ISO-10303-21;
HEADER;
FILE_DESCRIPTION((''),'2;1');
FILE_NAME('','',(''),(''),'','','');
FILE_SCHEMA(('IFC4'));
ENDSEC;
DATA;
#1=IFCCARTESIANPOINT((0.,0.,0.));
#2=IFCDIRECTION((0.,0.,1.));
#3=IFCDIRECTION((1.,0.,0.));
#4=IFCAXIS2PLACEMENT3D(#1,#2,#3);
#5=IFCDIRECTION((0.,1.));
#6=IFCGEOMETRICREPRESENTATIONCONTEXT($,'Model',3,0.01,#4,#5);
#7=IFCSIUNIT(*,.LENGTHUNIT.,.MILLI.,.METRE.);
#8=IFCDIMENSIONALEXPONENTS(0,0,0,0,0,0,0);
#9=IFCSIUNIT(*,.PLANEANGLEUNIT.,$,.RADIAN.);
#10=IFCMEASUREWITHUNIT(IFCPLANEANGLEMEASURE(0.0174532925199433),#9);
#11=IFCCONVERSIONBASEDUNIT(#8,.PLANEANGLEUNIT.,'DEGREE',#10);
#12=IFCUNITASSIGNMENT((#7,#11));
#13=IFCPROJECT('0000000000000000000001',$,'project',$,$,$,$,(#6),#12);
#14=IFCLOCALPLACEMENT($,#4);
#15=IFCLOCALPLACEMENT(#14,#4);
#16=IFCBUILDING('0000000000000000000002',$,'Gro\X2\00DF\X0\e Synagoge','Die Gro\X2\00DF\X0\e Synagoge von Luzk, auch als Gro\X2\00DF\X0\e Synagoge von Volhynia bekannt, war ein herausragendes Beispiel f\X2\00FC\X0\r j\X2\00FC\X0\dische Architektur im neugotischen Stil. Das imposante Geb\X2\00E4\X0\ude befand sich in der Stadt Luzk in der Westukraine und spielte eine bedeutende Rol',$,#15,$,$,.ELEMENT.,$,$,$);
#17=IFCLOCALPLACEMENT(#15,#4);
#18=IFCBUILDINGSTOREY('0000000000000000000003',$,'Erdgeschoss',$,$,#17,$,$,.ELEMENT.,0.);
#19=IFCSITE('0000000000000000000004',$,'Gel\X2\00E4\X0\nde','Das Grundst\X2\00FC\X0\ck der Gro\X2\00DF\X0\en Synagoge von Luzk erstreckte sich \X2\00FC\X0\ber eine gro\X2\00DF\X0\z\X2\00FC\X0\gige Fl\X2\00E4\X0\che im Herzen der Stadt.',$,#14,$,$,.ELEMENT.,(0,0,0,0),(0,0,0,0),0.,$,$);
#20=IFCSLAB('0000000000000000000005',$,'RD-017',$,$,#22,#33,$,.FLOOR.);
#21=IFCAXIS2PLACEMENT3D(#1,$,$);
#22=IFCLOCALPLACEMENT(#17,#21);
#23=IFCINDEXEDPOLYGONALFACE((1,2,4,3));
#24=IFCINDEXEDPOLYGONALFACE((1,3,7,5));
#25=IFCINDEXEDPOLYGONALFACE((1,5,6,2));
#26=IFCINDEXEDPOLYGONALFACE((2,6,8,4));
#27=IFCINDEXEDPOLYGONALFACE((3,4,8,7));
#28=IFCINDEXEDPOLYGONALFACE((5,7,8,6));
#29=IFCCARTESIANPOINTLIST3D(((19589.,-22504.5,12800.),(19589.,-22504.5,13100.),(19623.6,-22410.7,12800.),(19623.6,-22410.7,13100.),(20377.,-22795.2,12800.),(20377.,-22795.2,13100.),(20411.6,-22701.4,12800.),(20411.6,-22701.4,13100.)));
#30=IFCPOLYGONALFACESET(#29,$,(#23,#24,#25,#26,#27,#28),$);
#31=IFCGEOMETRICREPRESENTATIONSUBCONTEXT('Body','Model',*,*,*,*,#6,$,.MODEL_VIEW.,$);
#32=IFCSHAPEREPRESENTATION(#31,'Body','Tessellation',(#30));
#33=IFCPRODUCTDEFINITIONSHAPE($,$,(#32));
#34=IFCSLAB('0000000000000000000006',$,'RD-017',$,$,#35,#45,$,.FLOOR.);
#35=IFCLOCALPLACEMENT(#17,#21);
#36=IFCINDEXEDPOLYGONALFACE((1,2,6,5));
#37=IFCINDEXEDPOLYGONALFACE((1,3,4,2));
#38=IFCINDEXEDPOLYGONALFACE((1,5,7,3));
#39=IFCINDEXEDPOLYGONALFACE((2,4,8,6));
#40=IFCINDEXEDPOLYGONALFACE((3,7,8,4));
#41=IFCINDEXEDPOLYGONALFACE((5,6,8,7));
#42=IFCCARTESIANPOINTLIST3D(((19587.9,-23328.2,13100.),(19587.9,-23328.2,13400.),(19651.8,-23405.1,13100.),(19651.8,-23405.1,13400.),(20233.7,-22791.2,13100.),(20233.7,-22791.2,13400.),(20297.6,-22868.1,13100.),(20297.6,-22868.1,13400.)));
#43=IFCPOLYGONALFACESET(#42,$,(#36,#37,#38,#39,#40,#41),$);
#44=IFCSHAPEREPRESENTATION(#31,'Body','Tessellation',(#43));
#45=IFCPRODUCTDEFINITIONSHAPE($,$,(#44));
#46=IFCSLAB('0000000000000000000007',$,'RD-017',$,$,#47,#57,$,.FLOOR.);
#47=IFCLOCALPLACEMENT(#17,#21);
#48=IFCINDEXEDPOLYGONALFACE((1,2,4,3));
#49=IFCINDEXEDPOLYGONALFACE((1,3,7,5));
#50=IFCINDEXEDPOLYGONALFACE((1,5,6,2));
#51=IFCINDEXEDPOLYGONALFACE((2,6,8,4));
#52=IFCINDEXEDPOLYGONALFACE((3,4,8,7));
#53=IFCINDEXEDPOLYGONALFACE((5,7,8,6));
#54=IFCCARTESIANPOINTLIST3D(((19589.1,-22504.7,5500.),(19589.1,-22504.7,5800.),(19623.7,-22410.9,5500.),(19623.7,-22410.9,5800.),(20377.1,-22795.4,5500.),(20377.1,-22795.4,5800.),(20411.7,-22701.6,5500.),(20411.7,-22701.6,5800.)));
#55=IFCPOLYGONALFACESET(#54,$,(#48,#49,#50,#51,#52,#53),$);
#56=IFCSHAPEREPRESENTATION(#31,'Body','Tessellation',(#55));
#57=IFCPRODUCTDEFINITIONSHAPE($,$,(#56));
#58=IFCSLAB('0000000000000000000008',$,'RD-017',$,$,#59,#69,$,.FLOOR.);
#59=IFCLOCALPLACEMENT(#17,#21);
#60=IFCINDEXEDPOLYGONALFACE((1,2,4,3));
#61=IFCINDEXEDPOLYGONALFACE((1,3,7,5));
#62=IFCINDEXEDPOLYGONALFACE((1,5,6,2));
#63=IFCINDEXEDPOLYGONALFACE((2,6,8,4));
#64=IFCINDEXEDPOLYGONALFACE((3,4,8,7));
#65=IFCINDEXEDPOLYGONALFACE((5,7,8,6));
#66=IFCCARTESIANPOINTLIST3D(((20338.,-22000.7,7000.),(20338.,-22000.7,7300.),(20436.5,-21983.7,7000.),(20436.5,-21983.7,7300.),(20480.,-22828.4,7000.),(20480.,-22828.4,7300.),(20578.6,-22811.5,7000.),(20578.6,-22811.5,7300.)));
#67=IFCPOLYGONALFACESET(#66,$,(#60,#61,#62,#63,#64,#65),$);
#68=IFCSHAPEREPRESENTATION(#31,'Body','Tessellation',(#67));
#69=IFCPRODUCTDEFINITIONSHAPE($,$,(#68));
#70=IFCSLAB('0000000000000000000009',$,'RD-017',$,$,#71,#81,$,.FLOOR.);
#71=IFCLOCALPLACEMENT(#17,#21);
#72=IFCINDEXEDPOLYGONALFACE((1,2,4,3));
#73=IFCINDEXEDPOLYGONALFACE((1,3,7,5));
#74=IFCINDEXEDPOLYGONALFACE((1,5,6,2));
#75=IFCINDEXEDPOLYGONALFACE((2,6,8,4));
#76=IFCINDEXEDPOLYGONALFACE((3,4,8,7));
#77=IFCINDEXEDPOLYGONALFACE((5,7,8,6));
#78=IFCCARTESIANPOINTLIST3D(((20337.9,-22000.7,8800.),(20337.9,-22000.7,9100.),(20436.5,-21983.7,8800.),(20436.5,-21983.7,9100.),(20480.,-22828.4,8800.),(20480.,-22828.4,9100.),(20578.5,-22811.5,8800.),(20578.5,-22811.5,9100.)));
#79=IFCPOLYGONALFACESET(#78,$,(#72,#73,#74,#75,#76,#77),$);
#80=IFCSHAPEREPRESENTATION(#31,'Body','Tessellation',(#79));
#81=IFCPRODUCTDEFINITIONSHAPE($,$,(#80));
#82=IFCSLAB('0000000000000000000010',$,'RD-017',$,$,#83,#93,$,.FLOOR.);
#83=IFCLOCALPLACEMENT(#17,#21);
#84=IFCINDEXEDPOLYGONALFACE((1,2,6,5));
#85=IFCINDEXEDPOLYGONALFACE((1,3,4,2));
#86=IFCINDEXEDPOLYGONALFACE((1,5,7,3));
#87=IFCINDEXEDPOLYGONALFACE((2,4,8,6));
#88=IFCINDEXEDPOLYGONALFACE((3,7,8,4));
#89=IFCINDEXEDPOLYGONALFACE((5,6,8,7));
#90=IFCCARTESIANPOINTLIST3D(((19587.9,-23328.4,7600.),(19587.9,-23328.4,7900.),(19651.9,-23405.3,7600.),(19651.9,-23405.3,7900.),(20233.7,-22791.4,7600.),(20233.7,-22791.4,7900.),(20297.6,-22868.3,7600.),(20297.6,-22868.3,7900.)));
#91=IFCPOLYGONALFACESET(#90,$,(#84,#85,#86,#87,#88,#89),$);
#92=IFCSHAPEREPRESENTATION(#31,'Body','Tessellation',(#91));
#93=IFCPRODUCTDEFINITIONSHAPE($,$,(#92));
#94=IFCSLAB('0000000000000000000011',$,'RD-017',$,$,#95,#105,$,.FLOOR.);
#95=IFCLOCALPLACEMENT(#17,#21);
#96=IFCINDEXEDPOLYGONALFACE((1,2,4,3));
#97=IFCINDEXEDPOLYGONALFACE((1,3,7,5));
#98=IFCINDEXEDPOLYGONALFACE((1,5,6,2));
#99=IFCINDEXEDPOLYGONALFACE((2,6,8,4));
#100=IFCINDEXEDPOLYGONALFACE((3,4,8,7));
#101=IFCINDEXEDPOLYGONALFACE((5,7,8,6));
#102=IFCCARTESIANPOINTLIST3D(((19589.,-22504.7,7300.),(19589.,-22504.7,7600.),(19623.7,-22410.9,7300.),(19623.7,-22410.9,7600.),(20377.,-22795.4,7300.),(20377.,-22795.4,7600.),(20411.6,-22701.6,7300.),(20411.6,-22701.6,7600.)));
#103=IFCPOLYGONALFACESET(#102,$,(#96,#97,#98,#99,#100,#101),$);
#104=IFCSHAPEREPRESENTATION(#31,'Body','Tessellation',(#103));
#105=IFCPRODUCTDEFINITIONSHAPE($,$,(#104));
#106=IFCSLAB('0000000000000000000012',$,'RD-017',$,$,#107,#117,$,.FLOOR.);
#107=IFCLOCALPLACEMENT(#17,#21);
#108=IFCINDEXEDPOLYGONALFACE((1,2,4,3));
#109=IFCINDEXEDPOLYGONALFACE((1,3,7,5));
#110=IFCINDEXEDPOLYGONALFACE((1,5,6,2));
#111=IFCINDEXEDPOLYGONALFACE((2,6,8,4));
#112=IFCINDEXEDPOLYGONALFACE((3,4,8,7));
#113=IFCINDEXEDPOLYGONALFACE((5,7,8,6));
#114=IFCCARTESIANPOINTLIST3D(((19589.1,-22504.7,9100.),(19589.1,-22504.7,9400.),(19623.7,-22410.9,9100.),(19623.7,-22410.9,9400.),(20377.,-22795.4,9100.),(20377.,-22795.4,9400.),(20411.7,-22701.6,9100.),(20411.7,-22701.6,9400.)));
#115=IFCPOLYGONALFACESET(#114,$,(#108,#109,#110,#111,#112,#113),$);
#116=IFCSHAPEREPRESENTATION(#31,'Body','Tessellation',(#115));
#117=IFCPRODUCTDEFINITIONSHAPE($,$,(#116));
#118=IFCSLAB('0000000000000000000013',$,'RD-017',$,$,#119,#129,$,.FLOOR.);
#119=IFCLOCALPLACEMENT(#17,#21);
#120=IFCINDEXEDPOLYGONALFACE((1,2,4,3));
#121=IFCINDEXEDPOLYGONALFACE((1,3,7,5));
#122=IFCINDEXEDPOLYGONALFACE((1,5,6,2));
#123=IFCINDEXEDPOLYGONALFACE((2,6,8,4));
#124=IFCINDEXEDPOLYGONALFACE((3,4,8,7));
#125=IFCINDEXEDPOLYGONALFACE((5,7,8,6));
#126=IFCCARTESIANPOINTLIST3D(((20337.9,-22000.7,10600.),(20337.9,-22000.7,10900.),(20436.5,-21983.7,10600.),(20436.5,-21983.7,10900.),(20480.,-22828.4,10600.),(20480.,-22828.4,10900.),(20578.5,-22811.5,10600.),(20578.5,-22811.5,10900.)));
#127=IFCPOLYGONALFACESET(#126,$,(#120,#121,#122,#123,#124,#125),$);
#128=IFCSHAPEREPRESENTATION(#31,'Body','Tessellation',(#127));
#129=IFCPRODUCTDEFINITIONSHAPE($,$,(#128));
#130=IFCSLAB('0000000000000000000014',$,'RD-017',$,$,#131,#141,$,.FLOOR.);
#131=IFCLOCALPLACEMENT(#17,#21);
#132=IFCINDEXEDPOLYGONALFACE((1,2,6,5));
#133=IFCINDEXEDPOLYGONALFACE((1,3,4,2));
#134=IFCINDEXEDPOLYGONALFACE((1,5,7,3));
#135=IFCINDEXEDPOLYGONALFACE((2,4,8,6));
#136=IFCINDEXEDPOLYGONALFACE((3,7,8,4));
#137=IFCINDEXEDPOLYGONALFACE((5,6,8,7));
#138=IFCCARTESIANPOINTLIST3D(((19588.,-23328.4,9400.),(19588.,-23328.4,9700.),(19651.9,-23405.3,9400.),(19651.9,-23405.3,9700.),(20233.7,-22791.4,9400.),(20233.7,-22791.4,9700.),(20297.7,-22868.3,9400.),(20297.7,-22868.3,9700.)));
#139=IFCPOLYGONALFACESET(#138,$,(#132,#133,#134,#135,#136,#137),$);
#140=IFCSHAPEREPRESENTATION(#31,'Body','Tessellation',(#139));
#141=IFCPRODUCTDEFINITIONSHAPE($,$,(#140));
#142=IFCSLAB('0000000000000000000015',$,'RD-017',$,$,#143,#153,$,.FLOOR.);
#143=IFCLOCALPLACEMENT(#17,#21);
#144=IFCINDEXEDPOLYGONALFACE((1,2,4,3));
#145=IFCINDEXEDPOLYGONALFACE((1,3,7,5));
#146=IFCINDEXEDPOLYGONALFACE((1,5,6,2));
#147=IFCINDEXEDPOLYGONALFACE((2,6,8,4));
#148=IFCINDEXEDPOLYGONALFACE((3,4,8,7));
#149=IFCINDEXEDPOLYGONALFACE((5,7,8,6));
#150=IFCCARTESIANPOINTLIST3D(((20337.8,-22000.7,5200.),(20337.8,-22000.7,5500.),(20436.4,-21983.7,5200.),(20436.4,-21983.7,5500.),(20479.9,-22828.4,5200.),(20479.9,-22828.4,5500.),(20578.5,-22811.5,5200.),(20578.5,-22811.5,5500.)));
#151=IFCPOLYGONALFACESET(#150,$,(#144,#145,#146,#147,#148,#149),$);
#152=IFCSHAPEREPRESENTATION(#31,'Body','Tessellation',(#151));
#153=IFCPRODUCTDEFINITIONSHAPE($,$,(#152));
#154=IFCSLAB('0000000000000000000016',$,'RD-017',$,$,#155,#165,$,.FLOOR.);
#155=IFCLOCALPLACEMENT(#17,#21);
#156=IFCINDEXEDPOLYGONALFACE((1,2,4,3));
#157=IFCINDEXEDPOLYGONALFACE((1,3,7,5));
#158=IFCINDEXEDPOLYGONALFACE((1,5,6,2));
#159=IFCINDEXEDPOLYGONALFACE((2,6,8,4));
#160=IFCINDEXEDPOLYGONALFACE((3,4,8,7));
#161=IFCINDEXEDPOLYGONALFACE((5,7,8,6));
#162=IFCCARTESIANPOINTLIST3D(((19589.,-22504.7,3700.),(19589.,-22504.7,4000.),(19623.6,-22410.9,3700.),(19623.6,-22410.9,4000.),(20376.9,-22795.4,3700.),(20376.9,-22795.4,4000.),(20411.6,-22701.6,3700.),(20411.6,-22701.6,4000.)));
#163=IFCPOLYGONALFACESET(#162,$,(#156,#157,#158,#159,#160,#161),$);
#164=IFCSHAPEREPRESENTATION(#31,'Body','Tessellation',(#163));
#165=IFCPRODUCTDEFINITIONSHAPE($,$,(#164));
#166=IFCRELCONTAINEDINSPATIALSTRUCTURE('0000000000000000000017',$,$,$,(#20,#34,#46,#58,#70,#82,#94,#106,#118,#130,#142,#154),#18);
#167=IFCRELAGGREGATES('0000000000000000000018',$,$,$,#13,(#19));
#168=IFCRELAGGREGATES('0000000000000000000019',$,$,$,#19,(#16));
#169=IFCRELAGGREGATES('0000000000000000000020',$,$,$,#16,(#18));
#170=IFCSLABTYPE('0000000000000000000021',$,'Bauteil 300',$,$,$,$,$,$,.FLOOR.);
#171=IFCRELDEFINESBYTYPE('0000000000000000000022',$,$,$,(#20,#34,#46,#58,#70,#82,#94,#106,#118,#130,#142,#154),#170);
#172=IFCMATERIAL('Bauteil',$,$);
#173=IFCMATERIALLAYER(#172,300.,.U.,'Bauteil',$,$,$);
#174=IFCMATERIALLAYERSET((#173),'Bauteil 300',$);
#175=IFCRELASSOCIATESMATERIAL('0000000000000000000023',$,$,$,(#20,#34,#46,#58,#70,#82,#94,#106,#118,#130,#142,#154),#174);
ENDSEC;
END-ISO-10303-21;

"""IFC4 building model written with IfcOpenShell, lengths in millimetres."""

from ifc_helpers import new_model, entity, si_unit, converted_unit, direction, frame, origin_with_axes, place, context, subcontext, project, spatial, line, indexed_curve, outline, extrude, material, layer, layer_set, layer_usage, type_object, element, save


model = new_model("IFC4")

# Units and contexts
model_context = context("Model", 3, precision=0.01, world=origin_with_axes(), true_north=direction((0.0, 1.0)))
body_context = subcontext(model_context, "Body", "Model", "MODEL_VIEW")
ifc_project = project(units=[si_unit("LENGTHUNIT", "METRE", prefix="MILLI"), converted_unit("PLANEANGLEUNIT", "DEGREE", entity("IfcPlaneAngleMeasure", 0.0174532925199433), si_unit("PLANEANGLEUNIT", "RADIAN"), dimensions=[0, 0, 0, 0, 0, 0, 0])], contexts=[model_context])

# Site, building, storey
site_placement = place(None, origin_with_axes())
site = spatial("IfcSite", under=ifc_project, at=site_placement, Name="Gelände", Description="Das Grundstück der Großen Synagoge von Luzk erstreckte sich über eine großzügige Fläche im Herzen der Stadt.", CompositionType="ELEMENT", RefLatitude=(0, 0, 0, 0), RefLongitude=(0, 0, 0, 0), RefElevation=0.0)
building_placement = place(site_placement, origin_with_axes())
building = spatial("IfcBuilding", under=site, at=building_placement, Name="Große Synagoge", Description="Die Große Synagoge von Luzk, auch als Große Synagoge von Volhynia bekannt, war ein herausragendes Beispiel für jüdische Architektur im neugotischen Stil. Das imposante Gebäude befand sich in der Stadt Luzk in der Westukraine und spielte eine bedeutende Rol", CompositionType="ELEMENT")
storey_placement = place(building_placement, origin_with_axes())
storey = spatial("IfcBuildingStorey", under=building, at=storey_placement, Name="Erdgeschoss", CompositionType="ELEMENT", Elevation=0.0)

# Slabs
ifc_material = material(Name="Bauteil")
ifc_layer_1 = layer(ifc_material, 300.0, ventilated="UNKNOWN", Name="Bauteil")
ifc_layer_set_1 = layer_set([ifc_layer_1], Name="Bauteil 300")
ifc_layer_usage_1 = layer_usage(ifc_layer_set_1, "AXIS3", "NEGATIVE", 300.0)
slab_type_1 = type_object("IfcSlabType", Name="Bauteil 300", PredefinedType="FLOOR")
slab_1_placement = place(storey_placement, frame((20377.0, -22795.2, 13100.0), z_axis=(0.0, 0.0, 1.0), x_axis=(1.0, 0.0, 0.0)))
element("IfcSlab", 1, at=slab_1_placement, inside=storey, type_object=slab_type_1, material=ifc_layer_usage_1, Name="RD-017", PredefinedType="FLOOR", context=body_context, shape_type="SweptSolid", body=[
    extrude(outline(indexed_curve([(0.0, 0.0), (34.6, 93.8), (-753.4, 384.5), (-788.0, 290.7)], segments=[line(1, 2, 3, 4, 1)])), frame((0.0, 0.0, -300.0), z_axis=(0.0, 0.0, 1.0), x_axis=(1.0, 0.0, 0.0)), (0.0, 0.0, 1.0), 300.0),
])
ifc_layer_usage_2 = layer_usage(ifc_layer_set_1, "AXIS3", "NEGATIVE", 300.0)
slab_2_placement = place(storey_placement, frame((20297.6, -22868.1, 13400.0), z_axis=(0.0, 0.0, 1.0), x_axis=(1.0, 0.0, 0.0)))
element("IfcSlab", 2, at=slab_2_placement, inside=storey, type_object=slab_type_1, material=ifc_layer_usage_2, Name="RD-017", PredefinedType="FLOOR", context=body_context, shape_type="SweptSolid", body=[
    extrude(outline(indexed_curve([(0.0, 0.0), (-63.9, 76.9), (-709.7, -460.1), (-645.8, -537.0)], segments=[line(1, 2, 3, 4, 1)])), frame((0.0, 0.0, -300.0), z_axis=(0.0, 0.0, 1.0), x_axis=(1.0, 0.0, 0.0)), (0.0, 0.0, 1.0), 300.0),
])
ifc_layer_usage_3 = layer_usage(ifc_layer_set_1, "AXIS3", "NEGATIVE", 300.0)
slab_3_placement = place(storey_placement, frame((20377.1, -22795.4, 5800.0), z_axis=(0.0, 0.0, 1.0), x_axis=(1.0, 0.0, 0.0)))
element("IfcSlab", 3, at=slab_3_placement, inside=storey, type_object=slab_type_1, material=ifc_layer_usage_3, Name="RD-017", PredefinedType="FLOOR", context=body_context, shape_type="SweptSolid", body=[
    extrude(outline(indexed_curve([(0.0, 0.0), (34.6, 93.8), (-753.4, 384.5), (-788.0, 290.7)], segments=[line(1, 2, 3, 4, 1)])), frame((0.0, 0.0, -300.0), z_axis=(0.0, 0.0, 1.0), x_axis=(1.0, 0.0, 0.0)), (0.0, 0.0, 1.0), 300.0),
])
ifc_layer_usage_4 = layer_usage(ifc_layer_set_1, "AXIS3", "NEGATIVE", 300.0)
slab_4_placement = place(storey_placement, frame((20480.0, -22828.4, 7300.0), z_axis=(0.0, 0.0, 1.0), x_axis=(1.0, 0.0, 0.0)))
element("IfcSlab", 4, at=slab_4_placement, inside=storey, type_object=slab_type_1, material=ifc_layer_usage_4, Name="RD-017", PredefinedType="FLOOR", context=body_context, shape_type="SweptSolid", body=[
    extrude(outline(indexed_curve([(0.0, 0.0), (98.6, 16.9), (-43.5, 844.7), (-142.1, 827.8)], segments=[line(1, 2, 3, 4, 1)])), frame((0.0, 0.0, -300.0), z_axis=(0.0, 0.0, 1.0), x_axis=(1.0, 0.0, 0.0)), (0.0, 0.0, 1.0), 300.0),
])
ifc_layer_usage_5 = layer_usage(ifc_layer_set_1, "AXIS3", "NEGATIVE", 300.0)
slab_5_placement = place(storey_placement, frame((20480.0, -22828.4, 9100.0), z_axis=(0.0, 0.0, 1.0), x_axis=(1.0, 0.0, 0.0)))
element("IfcSlab", 5, at=slab_5_placement, inside=storey, type_object=slab_type_1, material=ifc_layer_usage_5, Name="RD-017", PredefinedType="FLOOR", context=body_context, shape_type="SweptSolid", body=[
    extrude(outline(indexed_curve([(0.0, 0.0), (98.6, 16.9), (-43.5, 844.7), (-142.1, 827.8)], segments=[line(1, 2, 3, 4, 1)])), frame((0.0, 0.0, -300.0), z_axis=(0.0, 0.0, 1.0), x_axis=(1.0, 0.0, 0.0)), (0.0, 0.0, 1.0), 300.0),
])
ifc_layer_usage_6 = layer_usage(ifc_layer_set_1, "AXIS3", "NEGATIVE", 300.0)
slab_6_placement = place(storey_placement, frame((20297.6, -22868.3, 7900.0), z_axis=(0.0, 0.0, 1.0), x_axis=(1.0, 0.0, 0.0)))
element("IfcSlab", 6, at=slab_6_placement, inside=storey, type_object=slab_type_1, material=ifc_layer_usage_6, Name="RD-017", PredefinedType="FLOOR", context=body_context, shape_type="SweptSolid", body=[
    extrude(outline(indexed_curve([(0.0, 0.0), (-63.9, 76.9), (-709.7, -460.1), (-645.8, -537.0)], segments=[line(1, 2, 3, 4, 1)])), frame((0.0, 0.0, -300.0), z_axis=(0.0, 0.0, 1.0), x_axis=(1.0, 0.0, 0.0)), (0.0, 0.0, 1.0), 300.0),
])
ifc_layer_usage_7 = layer_usage(ifc_layer_set_1, "AXIS3", "NEGATIVE", 300.0)
slab_7_placement = place(storey_placement, frame((20377.0, -22795.4, 7600.0), z_axis=(0.0, 0.0, 1.0), x_axis=(1.0, 0.0, 0.0)))
element("IfcSlab", 7, at=slab_7_placement, inside=storey, type_object=slab_type_1, material=ifc_layer_usage_7, Name="RD-017", PredefinedType="FLOOR", context=body_context, shape_type="SweptSolid", body=[
    extrude(outline(indexed_curve([(0.0, 0.0), (34.6, 93.8), (-753.4, 384.5), (-788.0, 290.7)], segments=[line(1, 2, 3, 4, 1)])), frame((0.0, 0.0, -300.0), z_axis=(0.0, 0.0, 1.0), x_axis=(1.0, 0.0, 0.0)), (0.0, 0.0, 1.0), 300.0),
])
ifc_layer_usage_8 = layer_usage(ifc_layer_set_1, "AXIS3", "NEGATIVE", 300.0)
slab_8_placement = place(storey_placement, frame((20377.0, -22795.4, 9400.0), z_axis=(0.0, 0.0, 1.0), x_axis=(1.0, 0.0, 0.0)))
element("IfcSlab", 8, at=slab_8_placement, inside=storey, type_object=slab_type_1, material=ifc_layer_usage_8, Name="RD-017", PredefinedType="FLOOR", context=body_context, shape_type="SweptSolid", body=[
    extrude(outline(indexed_curve([(0.0, 0.0), (34.6, 93.8), (-753.4, 384.5), (-788.0, 290.7)], segments=[line(1, 2, 3, 4, 1)])), frame((0.0, 0.0, -300.0), z_axis=(0.0, 0.0, 1.0), x_axis=(1.0, 0.0, 0.0)), (0.0, 0.0, 1.0), 300.0),
])
ifc_layer_usage_9 = layer_usage(ifc_layer_set_1, "AXIS3", "NEGATIVE", 300.0)
slab_9_placement = place(storey_placement, frame((20480.0, -22828.4, 10900.0), z_axis=(0.0, 0.0, 1.0), x_axis=(1.0, 0.0, 0.0)))
element("IfcSlab", 9, at=slab_9_placement, inside=storey, type_object=slab_type_1, material=ifc_layer_usage_9, Name="RD-017", PredefinedType="FLOOR", context=body_context, shape_type="SweptSolid", body=[
    extrude(outline(indexed_curve([(0.0, 0.0), (98.6, 16.9), (-43.5, 844.7), (-142.1, 827.8)], segments=[line(1, 2, 3, 4, 1)])), frame((0.0, 0.0, -300.0), z_axis=(0.0, 0.0, 1.0), x_axis=(1.0, 0.0, 0.0)), (0.0, 0.0, 1.0), 300.0),
])
ifc_layer_usage_10 = layer_usage(ifc_layer_set_1, "AXIS3", "NEGATIVE", 300.0)
slab_10_placement = place(storey_placement, frame((20297.7, -22868.3, 9700.0), z_axis=(0.0, 0.0, 1.0), x_axis=(1.0, 0.0, 0.0)))
element("IfcSlab", 10, at=slab_10_placement, inside=storey, type_object=slab_type_1, material=ifc_layer_usage_10, Name="RD-017", PredefinedType="FLOOR", context=body_context, shape_type="SweptSolid", body=[
    extrude(outline(indexed_curve([(0.0, 0.0), (-63.9, 76.9), (-709.7, -460.1), (-645.8, -537.0)], segments=[line(1, 2, 3, 4, 1)])), frame((0.0, 0.0, -300.0), z_axis=(0.0, 0.0, 1.0), x_axis=(1.0, 0.0, 0.0)), (0.0, 0.0, 1.0), 300.0),
])
ifc_layer_usage_11 = layer_usage(ifc_layer_set_1, "AXIS3", "NEGATIVE", 300.0)
slab_11_placement = place(storey_placement, frame((20479.9, -22828.4, 5500.0), z_axis=(0.0, 0.0, 1.0), x_axis=(1.0, 0.0, 0.0)))
element("IfcSlab", 11, at=slab_11_placement, inside=storey, type_object=slab_type_1, material=ifc_layer_usage_11, Name="RD-017", PredefinedType="FLOOR", context=body_context, shape_type="SweptSolid", body=[
    extrude(outline(indexed_curve([(0.0, 0.0), (98.6, 16.9), (-43.5, 844.7), (-142.1, 827.8)], segments=[line(1, 2, 3, 4, 1)])), frame((0.0, 0.0, -300.0), z_axis=(0.0, 0.0, 1.0), x_axis=(1.0, 0.0, 0.0)), (0.0, 0.0, 1.0), 300.0),
])
ifc_layer_usage_12 = layer_usage(ifc_layer_set_1, "AXIS3", "NEGATIVE", 300.0)
slab_12_placement = place(storey_placement, frame((20376.9, -22795.4, 4000.0), z_axis=(0.0, 0.0, 1.0), x_axis=(1.0, 0.0, 0.0)))
element("IfcSlab", 12, at=slab_12_placement, inside=storey, type_object=slab_type_1, material=ifc_layer_usage_12, Name="RD-017", PredefinedType="FLOOR", context=body_context, shape_type="SweptSolid", body=[
    extrude(outline(indexed_curve([(0.0, 0.0), (34.6, 93.8), (-753.4, 384.5), (-788.0, 290.7)], segments=[line(1, 2, 3, 4, 1)])), frame((0.0, 0.0, -300.0), z_axis=(0.0, 0.0, 1.0), x_axis=(1.0, 0.0, 0.0)), (0.0, 0.0, 1.0), 300.0),
])

save(model, "model.ifc")
